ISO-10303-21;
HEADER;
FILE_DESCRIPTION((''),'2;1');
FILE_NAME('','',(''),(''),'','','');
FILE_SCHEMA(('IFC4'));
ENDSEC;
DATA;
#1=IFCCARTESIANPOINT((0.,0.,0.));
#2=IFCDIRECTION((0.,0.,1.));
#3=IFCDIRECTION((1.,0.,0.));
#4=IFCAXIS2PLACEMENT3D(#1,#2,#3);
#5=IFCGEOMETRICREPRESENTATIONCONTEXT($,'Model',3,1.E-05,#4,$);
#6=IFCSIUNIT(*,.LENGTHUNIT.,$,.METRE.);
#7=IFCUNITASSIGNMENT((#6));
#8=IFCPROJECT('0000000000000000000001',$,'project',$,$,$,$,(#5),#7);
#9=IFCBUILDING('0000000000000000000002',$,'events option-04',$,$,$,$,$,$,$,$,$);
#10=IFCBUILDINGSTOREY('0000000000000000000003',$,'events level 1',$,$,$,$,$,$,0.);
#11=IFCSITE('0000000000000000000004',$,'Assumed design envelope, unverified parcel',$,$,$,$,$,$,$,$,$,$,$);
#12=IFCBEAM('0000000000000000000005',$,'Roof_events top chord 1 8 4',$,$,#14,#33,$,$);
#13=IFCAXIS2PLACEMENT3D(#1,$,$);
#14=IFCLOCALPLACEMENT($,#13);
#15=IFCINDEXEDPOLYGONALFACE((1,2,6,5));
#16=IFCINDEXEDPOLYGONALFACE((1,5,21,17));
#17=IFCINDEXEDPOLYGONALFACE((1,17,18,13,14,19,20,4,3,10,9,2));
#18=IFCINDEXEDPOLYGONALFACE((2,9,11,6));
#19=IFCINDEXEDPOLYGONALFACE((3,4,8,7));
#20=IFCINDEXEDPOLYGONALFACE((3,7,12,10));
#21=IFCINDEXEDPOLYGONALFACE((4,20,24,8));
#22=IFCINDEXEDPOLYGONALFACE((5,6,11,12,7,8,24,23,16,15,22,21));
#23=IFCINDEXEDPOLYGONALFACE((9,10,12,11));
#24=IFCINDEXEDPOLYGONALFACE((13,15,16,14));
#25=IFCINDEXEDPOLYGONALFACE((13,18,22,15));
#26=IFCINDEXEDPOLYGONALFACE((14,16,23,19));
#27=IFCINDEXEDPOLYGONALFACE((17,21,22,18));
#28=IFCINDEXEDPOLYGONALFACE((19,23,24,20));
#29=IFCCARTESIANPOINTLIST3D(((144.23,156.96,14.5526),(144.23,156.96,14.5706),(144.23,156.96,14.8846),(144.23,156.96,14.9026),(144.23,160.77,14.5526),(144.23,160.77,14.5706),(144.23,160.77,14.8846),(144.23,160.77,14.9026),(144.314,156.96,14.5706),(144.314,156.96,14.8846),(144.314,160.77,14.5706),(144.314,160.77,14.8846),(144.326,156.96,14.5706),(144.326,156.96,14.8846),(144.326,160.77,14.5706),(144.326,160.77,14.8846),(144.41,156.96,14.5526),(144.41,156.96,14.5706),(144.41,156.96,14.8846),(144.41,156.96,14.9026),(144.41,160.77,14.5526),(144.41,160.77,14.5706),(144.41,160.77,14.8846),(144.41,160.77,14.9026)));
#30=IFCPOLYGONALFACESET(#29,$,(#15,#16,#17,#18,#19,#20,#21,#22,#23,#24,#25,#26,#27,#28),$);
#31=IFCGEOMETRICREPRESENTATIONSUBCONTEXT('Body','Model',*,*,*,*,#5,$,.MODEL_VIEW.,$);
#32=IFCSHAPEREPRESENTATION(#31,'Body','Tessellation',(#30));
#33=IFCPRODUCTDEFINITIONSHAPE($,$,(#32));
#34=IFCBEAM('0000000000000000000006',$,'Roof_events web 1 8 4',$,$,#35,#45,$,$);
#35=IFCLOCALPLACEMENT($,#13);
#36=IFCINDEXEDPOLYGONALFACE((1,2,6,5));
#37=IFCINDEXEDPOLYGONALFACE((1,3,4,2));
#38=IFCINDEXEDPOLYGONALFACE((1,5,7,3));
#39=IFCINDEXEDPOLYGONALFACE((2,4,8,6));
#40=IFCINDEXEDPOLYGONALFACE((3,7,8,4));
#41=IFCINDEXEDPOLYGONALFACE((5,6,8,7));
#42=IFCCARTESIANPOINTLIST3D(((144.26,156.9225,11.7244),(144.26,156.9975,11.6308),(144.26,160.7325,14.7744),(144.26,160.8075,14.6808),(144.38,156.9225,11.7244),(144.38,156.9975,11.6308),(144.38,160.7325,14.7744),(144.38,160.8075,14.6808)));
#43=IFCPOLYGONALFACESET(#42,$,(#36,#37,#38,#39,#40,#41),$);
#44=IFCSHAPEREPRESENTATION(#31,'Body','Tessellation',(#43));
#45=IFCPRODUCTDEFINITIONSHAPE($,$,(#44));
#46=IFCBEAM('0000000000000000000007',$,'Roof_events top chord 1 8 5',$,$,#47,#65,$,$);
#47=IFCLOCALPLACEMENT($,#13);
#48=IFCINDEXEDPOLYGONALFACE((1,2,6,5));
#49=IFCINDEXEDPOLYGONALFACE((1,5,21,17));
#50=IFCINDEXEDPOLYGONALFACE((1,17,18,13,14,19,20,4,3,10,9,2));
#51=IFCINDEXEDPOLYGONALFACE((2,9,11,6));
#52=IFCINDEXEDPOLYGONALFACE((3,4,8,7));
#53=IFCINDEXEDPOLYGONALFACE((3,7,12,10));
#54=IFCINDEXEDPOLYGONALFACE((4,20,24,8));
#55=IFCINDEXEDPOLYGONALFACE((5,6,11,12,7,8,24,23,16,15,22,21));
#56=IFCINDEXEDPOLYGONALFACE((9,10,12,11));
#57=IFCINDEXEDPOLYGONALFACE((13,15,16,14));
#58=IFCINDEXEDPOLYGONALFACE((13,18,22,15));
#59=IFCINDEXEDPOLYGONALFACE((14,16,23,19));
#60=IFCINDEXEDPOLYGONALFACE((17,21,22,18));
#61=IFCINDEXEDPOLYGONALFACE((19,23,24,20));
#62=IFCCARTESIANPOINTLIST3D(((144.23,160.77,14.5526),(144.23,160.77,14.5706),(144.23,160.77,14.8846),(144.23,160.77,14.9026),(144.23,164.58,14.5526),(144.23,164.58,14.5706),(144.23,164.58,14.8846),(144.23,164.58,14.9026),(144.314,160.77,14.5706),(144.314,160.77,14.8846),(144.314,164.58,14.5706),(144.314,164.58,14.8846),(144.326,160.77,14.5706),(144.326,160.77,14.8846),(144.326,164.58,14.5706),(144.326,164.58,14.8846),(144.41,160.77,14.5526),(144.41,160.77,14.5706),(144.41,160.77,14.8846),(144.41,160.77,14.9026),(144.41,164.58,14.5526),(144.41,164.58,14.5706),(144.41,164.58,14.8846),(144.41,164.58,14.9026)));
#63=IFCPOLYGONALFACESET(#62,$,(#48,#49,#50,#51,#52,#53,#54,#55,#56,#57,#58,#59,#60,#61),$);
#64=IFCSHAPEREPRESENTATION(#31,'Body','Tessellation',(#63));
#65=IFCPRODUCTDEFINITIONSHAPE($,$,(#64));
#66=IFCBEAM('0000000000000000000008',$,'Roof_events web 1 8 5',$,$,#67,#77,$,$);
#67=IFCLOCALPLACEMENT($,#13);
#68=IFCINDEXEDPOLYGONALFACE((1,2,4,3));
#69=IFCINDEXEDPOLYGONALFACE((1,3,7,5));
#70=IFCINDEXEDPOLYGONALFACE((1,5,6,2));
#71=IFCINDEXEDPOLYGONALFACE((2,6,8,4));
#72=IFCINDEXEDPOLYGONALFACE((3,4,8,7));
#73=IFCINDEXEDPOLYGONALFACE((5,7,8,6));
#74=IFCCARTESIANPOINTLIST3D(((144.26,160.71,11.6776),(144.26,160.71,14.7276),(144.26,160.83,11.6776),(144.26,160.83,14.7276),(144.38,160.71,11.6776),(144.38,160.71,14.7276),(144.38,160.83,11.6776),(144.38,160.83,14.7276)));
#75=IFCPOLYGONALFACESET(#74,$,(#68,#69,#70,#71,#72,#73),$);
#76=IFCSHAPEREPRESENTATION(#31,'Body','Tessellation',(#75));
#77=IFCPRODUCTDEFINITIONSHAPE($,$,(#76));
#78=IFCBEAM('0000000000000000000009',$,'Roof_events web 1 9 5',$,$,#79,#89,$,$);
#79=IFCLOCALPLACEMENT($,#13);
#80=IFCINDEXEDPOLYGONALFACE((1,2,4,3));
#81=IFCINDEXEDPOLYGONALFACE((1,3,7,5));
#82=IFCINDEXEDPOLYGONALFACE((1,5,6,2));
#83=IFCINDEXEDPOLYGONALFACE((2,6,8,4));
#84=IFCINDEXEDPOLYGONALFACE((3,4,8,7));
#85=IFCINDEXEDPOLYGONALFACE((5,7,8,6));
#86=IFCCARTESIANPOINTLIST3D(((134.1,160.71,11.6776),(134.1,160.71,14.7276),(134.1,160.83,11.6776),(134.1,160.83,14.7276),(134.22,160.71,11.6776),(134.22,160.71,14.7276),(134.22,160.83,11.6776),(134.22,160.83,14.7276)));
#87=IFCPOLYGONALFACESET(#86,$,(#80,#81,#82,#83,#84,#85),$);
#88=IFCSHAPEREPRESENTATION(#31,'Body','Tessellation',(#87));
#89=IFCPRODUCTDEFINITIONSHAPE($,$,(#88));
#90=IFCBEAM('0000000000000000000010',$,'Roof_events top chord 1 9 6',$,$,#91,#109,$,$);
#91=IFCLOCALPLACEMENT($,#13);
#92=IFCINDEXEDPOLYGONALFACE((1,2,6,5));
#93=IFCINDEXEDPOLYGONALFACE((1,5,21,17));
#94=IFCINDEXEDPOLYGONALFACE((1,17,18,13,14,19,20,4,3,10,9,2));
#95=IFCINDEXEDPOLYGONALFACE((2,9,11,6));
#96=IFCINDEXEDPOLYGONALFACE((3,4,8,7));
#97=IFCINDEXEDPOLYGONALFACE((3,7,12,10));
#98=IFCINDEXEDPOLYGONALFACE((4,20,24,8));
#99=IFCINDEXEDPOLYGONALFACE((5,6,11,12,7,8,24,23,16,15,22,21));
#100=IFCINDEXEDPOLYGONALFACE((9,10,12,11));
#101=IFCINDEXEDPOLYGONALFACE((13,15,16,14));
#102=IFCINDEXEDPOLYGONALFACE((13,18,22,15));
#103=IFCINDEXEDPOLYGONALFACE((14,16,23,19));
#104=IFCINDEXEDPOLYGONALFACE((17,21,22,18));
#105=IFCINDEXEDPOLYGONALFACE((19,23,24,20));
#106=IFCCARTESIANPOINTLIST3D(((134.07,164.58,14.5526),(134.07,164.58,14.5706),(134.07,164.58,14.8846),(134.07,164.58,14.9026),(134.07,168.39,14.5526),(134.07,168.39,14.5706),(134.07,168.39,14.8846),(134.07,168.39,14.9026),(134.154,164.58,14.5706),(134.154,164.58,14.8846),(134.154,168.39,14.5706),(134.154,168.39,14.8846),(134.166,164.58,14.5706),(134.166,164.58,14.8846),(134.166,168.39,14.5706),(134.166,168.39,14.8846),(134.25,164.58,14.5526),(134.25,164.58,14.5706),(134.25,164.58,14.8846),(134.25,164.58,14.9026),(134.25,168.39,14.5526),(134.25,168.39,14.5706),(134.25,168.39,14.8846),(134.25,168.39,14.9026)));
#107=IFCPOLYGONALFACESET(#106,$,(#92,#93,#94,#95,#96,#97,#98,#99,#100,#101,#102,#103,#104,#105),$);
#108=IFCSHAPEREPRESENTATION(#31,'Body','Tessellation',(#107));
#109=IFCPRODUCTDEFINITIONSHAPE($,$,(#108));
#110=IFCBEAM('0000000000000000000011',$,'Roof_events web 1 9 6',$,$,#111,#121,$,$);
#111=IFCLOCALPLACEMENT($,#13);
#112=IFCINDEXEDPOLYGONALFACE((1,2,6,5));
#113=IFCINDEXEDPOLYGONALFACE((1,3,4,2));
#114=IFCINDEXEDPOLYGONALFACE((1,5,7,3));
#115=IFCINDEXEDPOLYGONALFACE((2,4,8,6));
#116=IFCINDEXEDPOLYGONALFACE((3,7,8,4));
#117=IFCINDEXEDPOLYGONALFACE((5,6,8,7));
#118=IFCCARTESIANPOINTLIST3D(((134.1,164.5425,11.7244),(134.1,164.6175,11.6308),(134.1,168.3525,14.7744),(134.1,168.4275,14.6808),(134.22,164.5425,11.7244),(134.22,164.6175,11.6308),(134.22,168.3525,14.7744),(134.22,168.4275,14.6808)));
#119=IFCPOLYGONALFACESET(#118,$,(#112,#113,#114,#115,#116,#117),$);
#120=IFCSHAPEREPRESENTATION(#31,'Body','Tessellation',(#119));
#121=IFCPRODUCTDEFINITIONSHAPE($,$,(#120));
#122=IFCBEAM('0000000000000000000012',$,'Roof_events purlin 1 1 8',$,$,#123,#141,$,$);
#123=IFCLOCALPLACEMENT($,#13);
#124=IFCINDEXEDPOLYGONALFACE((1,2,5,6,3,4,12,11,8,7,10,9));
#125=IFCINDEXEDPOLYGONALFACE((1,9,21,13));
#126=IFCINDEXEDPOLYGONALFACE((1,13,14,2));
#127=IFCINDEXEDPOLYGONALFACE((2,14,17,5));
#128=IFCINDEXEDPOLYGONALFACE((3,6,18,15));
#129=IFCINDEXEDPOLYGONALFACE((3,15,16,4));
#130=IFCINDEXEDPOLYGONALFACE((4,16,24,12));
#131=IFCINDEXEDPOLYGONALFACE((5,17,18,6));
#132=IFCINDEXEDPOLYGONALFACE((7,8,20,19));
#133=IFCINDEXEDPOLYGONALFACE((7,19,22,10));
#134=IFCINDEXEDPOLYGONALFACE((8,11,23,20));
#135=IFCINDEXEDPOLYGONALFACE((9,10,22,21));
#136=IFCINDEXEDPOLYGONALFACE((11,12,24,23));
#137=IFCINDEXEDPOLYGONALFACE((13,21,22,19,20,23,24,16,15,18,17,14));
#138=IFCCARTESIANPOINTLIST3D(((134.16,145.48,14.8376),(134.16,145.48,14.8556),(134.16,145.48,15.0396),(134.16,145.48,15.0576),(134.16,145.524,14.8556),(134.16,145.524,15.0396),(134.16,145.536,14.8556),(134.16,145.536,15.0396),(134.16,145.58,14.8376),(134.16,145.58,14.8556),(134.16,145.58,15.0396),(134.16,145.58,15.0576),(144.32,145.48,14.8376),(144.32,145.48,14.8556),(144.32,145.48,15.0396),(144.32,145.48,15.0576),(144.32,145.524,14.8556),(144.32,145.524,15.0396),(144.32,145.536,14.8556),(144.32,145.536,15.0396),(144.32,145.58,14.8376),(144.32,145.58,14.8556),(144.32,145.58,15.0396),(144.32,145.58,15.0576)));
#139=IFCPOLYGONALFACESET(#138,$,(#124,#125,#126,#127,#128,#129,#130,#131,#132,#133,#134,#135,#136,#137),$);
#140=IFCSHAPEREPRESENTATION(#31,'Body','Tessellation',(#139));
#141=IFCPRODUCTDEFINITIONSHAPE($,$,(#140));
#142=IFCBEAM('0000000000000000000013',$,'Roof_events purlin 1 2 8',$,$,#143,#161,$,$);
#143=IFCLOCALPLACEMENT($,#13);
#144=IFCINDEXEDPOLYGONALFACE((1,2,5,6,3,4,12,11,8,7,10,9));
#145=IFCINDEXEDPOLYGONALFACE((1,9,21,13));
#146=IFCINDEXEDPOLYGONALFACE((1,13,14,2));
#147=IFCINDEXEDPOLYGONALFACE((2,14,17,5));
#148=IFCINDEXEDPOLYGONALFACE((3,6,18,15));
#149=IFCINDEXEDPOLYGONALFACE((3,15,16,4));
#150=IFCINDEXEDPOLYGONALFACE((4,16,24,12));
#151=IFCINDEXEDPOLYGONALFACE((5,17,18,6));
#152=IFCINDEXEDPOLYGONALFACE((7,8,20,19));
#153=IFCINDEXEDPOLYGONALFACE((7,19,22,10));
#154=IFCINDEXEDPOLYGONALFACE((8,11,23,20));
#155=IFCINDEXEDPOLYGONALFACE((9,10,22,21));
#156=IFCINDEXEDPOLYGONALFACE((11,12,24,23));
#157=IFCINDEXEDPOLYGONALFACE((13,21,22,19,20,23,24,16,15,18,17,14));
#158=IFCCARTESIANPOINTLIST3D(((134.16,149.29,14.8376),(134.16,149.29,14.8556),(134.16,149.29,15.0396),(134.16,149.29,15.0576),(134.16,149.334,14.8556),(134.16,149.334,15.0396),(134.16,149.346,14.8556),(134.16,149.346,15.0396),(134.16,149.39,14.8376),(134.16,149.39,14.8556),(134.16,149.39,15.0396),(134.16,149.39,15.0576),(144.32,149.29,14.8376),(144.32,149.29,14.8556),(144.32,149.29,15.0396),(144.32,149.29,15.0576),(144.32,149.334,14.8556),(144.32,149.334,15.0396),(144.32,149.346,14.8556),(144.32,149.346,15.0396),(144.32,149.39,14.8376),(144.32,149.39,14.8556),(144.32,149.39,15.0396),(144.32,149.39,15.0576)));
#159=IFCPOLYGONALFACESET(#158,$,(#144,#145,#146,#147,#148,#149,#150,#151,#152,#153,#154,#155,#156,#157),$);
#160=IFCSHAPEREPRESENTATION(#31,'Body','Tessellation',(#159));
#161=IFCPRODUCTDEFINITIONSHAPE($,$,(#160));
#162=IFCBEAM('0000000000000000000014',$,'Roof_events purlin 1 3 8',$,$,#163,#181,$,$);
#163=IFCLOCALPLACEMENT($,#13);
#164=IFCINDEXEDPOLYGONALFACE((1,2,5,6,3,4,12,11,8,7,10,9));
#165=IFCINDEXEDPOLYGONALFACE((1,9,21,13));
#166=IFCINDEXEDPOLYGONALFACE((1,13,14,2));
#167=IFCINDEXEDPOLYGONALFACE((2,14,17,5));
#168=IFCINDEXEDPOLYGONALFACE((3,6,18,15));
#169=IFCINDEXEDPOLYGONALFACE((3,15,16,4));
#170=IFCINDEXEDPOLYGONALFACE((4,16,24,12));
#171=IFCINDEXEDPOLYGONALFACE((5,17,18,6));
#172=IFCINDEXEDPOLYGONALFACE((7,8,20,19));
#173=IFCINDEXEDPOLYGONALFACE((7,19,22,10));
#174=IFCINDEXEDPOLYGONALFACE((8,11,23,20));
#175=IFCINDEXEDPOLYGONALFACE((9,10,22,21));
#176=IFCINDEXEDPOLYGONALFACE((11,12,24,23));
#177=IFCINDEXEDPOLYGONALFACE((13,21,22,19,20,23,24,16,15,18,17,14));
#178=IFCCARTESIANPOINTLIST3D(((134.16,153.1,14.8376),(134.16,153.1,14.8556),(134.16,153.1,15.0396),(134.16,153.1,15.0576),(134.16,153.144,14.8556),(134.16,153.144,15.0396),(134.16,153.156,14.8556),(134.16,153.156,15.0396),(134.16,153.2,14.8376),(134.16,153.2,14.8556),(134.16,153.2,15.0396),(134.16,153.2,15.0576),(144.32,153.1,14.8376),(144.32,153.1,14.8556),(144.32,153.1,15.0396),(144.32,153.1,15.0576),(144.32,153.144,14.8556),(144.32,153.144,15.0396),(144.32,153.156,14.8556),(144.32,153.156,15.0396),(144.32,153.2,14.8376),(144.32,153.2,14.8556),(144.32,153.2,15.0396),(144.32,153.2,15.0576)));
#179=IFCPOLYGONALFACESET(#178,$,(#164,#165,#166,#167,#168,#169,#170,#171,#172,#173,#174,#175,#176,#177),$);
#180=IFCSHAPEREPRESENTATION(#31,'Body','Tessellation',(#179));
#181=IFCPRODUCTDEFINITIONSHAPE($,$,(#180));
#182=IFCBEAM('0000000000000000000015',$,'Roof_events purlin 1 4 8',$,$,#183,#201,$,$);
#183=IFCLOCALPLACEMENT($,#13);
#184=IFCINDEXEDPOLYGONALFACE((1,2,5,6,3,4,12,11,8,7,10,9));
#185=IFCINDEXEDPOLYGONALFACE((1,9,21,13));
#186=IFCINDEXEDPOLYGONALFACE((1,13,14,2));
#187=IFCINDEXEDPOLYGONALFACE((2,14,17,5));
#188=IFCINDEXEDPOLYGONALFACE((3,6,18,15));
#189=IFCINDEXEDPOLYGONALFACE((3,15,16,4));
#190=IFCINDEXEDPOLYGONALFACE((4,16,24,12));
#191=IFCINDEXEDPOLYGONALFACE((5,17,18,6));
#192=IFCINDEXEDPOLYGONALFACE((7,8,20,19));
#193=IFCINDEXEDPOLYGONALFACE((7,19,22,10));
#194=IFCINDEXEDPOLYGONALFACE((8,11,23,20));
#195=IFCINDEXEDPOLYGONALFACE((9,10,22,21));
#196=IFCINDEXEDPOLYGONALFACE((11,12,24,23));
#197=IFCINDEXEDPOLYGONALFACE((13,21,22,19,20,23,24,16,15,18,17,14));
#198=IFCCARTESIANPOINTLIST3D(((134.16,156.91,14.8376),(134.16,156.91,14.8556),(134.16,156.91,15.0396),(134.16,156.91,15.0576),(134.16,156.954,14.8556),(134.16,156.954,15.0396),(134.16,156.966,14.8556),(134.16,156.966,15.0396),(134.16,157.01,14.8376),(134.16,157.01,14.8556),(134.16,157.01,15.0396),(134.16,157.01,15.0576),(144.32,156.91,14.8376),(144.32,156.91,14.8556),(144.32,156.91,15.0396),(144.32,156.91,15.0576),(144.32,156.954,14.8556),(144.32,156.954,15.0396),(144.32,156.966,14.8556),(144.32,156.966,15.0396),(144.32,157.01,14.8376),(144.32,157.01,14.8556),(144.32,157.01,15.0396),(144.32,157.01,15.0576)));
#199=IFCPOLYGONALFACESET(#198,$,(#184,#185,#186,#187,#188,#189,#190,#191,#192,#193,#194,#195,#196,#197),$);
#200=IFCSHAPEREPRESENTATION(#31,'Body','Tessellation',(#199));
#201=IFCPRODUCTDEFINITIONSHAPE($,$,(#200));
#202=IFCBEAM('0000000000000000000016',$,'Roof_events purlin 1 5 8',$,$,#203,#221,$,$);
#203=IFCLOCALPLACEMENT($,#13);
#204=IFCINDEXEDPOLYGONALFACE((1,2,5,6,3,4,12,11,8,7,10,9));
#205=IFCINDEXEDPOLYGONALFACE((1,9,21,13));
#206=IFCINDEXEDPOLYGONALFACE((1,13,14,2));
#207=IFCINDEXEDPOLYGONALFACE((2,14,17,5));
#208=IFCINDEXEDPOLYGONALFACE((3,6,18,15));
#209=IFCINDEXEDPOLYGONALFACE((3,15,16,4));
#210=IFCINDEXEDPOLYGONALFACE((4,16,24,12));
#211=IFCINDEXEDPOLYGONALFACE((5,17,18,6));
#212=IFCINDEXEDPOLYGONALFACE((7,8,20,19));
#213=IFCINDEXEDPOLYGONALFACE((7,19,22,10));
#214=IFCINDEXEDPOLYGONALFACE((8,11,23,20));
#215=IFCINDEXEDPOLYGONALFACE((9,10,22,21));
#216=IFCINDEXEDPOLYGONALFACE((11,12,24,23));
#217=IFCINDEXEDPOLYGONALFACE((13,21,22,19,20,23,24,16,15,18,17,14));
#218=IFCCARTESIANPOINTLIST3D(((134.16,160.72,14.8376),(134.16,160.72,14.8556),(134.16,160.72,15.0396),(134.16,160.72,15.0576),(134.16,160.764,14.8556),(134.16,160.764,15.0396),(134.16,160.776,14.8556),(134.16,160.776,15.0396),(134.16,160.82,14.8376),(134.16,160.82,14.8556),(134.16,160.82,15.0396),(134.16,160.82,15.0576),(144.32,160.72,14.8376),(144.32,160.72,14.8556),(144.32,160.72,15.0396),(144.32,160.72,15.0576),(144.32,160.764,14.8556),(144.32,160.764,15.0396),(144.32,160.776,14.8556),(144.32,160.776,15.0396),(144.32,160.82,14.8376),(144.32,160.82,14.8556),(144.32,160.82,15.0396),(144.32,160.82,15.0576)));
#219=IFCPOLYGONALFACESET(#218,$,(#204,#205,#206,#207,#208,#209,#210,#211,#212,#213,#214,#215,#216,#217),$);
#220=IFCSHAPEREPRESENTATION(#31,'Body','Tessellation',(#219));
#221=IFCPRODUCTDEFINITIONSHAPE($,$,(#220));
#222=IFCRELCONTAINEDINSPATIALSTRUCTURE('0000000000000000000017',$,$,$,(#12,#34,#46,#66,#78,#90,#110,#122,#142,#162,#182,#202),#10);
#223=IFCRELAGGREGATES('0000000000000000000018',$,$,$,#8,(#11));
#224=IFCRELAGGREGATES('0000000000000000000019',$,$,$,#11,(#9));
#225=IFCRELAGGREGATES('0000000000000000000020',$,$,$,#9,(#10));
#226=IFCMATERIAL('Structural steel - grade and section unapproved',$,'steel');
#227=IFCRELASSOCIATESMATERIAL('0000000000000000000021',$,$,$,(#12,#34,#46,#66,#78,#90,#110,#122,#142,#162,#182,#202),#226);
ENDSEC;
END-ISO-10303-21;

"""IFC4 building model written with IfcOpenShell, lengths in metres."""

from ifc_helpers import new_model, si_unit, frame, origin_with_axes, place, context, subcontext, project, spatial, rectangle, i_section, extrude, material, element, save


model = new_model("IFC4")

# Units and contexts
model_context = context("Model", 3, precision=1e-05, world=origin_with_axes())
body_context = subcontext(model_context, "Body", "Model", "MODEL_VIEW")
ifc_project = project(units=[si_unit("LENGTHUNIT", "METRE")], contexts=[model_context])

# Site, building, storey
site = spatial("IfcSite", under=ifc_project, Name="Assumed design envelope, unverified parcel")
building = spatial("IfcBuilding", under=site, Name="events option-04")
storey = spatial("IfcBuildingStorey", under=building, Name="events level 1", Elevation=0.0)

# Shared definitions
ifc_material_1 = material(Name="Structural steel - grade and section unapproved", Category="steel")

# Beams
beam_1_placement = place(None, frame((144.32, 156.96, 14.7276), z_axis=(0.0, 1.0, 0.0), x_axis=(-1.0, 0.0, 0.0)))
element("IfcBeam", 1, at=beam_1_placement, inside=storey, material=ifc_material_1, Name="Roof_events top chord 1 8 4", context=body_context, shape_type="SweptSolid", body=[
    extrude(i_section(OverallWidth=0.18, OverallDepth=0.35, WebThickness=0.012, FlangeThickness=0.018, FilletRadius=0.0), origin_with_axes(), (0.0, 0.0, 1.0), 3.81),
])
beam_2_placement = place(None, frame((144.32, 156.96, 11.6776), z_axis=(0.0, 0.780669, 0.624945), x_axis=(-1.0, 0.0, 0.0)))
element("IfcBeam", 2, at=beam_2_placement, inside=storey, material=ifc_material_1, Name="Roof_events web 1 8 4", context=body_context, shape_type="SweptSolid", body=[
    extrude(rectangle(XDim=0.12, YDim=0.12), origin_with_axes(), (0.0, 0.0, 1.0), 4.8804),
])
beam_3_placement = place(None, frame((144.32, 160.77, 14.7276), z_axis=(0.0, 1.0, 0.0), x_axis=(-1.0, 0.0, 0.0)))
element("IfcBeam", 3, at=beam_3_placement, inside=storey, material=ifc_material_1, Name="Roof_events top chord 1 8 5", context=body_context, shape_type="SweptSolid", body=[
    extrude(i_section(OverallWidth=0.18, OverallDepth=0.35, WebThickness=0.012, FlangeThickness=0.018, FilletRadius=0.0), origin_with_axes(), (0.0, 0.0, 1.0), 3.81),
])
for number, where, z_axis, x_axis, name in (
    (4, (144.32, 160.77, 11.6776), (0.0, 0.0, 1.0), (-1.0, 0.0, 0.0), "Roof_events web 1 8 5"),
    (5, (134.16, 160.77, 11.6776), (0.0, 0.0, 1.0), (-1.0, 0.0, 0.0), "Roof_events web 1 9 5"),
):
    element("IfcBeam", number, at=place(None, frame(where, z_axis=z_axis, x_axis=x_axis)), inside=storey, material=ifc_material_1, Name=name, context=body_context, shape_type="SweptSolid", body=[
        extrude(rectangle(XDim=0.12, YDim=0.12), origin_with_axes(), (0.0, 0.0, 1.0), 3.05),
    ])
beam_4_placement = place(None, frame((134.16, 164.58, 14.7276), z_axis=(0.0, 1.0, 0.0), x_axis=(-1.0, 0.0, 0.0)))
element("IfcBeam", 6, at=beam_4_placement, inside=storey, material=ifc_material_1, Name="Roof_events top chord 1 9 6", context=body_context, shape_type="SweptSolid", body=[
    extrude(i_section(OverallWidth=0.18, OverallDepth=0.35, WebThickness=0.012, FlangeThickness=0.018, FilletRadius=0.0), origin_with_axes(), (0.0, 0.0, 1.0), 3.81),
])
beam_5_placement = place(None, frame((134.16, 164.58, 11.6776), z_axis=(0.0, 0.780669, 0.624945), x_axis=(-1.0, 0.0, 0.0)))
element("IfcBeam", 7, at=beam_5_placement, inside=storey, material=ifc_material_1, Name="Roof_events web 1 9 6", context=body_context, shape_type="SweptSolid", body=[
    extrude(rectangle(XDim=0.12, YDim=0.12), origin_with_axes(), (0.0, 0.0, 1.0), 4.8804),
])
for number, where, z_axis, x_axis, name in (
    (8, (144.32, 145.53, 14.9476), (-1.0, 0.0, 0.0), (0.0, -1.0, 0.0), "Roof_events purlin 1 1 8"),
    (9, (144.32, 149.34, 14.9476), (-1.0, 0.0, 0.0), (0.0, -1.0, 0.0), "Roof_events purlin 1 2 8"),
    (10, (144.32, 153.15, 14.9476), (-1.0, 0.0, 0.0), (0.0, -1.0, 0.0), "Roof_events purlin 1 3 8"),
    (11, (144.32, 156.96, 14.9476), (-1.0, 0.0, 0.0), (0.0, -1.0, 0.0), "Roof_events purlin 1 4 8"),
    (12, (144.32, 160.77, 14.9476), (-1.0, 0.0, 0.0), (0.0, -1.0, 0.0), "Roof_events purlin 1 5 8"),
):
    element("IfcBeam", number, at=place(None, frame(where, z_axis=z_axis, x_axis=x_axis)), inside=storey, material=ifc_material_1, Name=name, context=body_context, shape_type="SweptSolid", body=[
        extrude(i_section(OverallWidth=0.1, OverallDepth=0.22, WebThickness=0.012, FlangeThickness=0.018, FilletRadius=0.0), origin_with_axes(), (0.0, 0.0, 1.0), 10.16),
    ])

save(model, "model.ifc")
